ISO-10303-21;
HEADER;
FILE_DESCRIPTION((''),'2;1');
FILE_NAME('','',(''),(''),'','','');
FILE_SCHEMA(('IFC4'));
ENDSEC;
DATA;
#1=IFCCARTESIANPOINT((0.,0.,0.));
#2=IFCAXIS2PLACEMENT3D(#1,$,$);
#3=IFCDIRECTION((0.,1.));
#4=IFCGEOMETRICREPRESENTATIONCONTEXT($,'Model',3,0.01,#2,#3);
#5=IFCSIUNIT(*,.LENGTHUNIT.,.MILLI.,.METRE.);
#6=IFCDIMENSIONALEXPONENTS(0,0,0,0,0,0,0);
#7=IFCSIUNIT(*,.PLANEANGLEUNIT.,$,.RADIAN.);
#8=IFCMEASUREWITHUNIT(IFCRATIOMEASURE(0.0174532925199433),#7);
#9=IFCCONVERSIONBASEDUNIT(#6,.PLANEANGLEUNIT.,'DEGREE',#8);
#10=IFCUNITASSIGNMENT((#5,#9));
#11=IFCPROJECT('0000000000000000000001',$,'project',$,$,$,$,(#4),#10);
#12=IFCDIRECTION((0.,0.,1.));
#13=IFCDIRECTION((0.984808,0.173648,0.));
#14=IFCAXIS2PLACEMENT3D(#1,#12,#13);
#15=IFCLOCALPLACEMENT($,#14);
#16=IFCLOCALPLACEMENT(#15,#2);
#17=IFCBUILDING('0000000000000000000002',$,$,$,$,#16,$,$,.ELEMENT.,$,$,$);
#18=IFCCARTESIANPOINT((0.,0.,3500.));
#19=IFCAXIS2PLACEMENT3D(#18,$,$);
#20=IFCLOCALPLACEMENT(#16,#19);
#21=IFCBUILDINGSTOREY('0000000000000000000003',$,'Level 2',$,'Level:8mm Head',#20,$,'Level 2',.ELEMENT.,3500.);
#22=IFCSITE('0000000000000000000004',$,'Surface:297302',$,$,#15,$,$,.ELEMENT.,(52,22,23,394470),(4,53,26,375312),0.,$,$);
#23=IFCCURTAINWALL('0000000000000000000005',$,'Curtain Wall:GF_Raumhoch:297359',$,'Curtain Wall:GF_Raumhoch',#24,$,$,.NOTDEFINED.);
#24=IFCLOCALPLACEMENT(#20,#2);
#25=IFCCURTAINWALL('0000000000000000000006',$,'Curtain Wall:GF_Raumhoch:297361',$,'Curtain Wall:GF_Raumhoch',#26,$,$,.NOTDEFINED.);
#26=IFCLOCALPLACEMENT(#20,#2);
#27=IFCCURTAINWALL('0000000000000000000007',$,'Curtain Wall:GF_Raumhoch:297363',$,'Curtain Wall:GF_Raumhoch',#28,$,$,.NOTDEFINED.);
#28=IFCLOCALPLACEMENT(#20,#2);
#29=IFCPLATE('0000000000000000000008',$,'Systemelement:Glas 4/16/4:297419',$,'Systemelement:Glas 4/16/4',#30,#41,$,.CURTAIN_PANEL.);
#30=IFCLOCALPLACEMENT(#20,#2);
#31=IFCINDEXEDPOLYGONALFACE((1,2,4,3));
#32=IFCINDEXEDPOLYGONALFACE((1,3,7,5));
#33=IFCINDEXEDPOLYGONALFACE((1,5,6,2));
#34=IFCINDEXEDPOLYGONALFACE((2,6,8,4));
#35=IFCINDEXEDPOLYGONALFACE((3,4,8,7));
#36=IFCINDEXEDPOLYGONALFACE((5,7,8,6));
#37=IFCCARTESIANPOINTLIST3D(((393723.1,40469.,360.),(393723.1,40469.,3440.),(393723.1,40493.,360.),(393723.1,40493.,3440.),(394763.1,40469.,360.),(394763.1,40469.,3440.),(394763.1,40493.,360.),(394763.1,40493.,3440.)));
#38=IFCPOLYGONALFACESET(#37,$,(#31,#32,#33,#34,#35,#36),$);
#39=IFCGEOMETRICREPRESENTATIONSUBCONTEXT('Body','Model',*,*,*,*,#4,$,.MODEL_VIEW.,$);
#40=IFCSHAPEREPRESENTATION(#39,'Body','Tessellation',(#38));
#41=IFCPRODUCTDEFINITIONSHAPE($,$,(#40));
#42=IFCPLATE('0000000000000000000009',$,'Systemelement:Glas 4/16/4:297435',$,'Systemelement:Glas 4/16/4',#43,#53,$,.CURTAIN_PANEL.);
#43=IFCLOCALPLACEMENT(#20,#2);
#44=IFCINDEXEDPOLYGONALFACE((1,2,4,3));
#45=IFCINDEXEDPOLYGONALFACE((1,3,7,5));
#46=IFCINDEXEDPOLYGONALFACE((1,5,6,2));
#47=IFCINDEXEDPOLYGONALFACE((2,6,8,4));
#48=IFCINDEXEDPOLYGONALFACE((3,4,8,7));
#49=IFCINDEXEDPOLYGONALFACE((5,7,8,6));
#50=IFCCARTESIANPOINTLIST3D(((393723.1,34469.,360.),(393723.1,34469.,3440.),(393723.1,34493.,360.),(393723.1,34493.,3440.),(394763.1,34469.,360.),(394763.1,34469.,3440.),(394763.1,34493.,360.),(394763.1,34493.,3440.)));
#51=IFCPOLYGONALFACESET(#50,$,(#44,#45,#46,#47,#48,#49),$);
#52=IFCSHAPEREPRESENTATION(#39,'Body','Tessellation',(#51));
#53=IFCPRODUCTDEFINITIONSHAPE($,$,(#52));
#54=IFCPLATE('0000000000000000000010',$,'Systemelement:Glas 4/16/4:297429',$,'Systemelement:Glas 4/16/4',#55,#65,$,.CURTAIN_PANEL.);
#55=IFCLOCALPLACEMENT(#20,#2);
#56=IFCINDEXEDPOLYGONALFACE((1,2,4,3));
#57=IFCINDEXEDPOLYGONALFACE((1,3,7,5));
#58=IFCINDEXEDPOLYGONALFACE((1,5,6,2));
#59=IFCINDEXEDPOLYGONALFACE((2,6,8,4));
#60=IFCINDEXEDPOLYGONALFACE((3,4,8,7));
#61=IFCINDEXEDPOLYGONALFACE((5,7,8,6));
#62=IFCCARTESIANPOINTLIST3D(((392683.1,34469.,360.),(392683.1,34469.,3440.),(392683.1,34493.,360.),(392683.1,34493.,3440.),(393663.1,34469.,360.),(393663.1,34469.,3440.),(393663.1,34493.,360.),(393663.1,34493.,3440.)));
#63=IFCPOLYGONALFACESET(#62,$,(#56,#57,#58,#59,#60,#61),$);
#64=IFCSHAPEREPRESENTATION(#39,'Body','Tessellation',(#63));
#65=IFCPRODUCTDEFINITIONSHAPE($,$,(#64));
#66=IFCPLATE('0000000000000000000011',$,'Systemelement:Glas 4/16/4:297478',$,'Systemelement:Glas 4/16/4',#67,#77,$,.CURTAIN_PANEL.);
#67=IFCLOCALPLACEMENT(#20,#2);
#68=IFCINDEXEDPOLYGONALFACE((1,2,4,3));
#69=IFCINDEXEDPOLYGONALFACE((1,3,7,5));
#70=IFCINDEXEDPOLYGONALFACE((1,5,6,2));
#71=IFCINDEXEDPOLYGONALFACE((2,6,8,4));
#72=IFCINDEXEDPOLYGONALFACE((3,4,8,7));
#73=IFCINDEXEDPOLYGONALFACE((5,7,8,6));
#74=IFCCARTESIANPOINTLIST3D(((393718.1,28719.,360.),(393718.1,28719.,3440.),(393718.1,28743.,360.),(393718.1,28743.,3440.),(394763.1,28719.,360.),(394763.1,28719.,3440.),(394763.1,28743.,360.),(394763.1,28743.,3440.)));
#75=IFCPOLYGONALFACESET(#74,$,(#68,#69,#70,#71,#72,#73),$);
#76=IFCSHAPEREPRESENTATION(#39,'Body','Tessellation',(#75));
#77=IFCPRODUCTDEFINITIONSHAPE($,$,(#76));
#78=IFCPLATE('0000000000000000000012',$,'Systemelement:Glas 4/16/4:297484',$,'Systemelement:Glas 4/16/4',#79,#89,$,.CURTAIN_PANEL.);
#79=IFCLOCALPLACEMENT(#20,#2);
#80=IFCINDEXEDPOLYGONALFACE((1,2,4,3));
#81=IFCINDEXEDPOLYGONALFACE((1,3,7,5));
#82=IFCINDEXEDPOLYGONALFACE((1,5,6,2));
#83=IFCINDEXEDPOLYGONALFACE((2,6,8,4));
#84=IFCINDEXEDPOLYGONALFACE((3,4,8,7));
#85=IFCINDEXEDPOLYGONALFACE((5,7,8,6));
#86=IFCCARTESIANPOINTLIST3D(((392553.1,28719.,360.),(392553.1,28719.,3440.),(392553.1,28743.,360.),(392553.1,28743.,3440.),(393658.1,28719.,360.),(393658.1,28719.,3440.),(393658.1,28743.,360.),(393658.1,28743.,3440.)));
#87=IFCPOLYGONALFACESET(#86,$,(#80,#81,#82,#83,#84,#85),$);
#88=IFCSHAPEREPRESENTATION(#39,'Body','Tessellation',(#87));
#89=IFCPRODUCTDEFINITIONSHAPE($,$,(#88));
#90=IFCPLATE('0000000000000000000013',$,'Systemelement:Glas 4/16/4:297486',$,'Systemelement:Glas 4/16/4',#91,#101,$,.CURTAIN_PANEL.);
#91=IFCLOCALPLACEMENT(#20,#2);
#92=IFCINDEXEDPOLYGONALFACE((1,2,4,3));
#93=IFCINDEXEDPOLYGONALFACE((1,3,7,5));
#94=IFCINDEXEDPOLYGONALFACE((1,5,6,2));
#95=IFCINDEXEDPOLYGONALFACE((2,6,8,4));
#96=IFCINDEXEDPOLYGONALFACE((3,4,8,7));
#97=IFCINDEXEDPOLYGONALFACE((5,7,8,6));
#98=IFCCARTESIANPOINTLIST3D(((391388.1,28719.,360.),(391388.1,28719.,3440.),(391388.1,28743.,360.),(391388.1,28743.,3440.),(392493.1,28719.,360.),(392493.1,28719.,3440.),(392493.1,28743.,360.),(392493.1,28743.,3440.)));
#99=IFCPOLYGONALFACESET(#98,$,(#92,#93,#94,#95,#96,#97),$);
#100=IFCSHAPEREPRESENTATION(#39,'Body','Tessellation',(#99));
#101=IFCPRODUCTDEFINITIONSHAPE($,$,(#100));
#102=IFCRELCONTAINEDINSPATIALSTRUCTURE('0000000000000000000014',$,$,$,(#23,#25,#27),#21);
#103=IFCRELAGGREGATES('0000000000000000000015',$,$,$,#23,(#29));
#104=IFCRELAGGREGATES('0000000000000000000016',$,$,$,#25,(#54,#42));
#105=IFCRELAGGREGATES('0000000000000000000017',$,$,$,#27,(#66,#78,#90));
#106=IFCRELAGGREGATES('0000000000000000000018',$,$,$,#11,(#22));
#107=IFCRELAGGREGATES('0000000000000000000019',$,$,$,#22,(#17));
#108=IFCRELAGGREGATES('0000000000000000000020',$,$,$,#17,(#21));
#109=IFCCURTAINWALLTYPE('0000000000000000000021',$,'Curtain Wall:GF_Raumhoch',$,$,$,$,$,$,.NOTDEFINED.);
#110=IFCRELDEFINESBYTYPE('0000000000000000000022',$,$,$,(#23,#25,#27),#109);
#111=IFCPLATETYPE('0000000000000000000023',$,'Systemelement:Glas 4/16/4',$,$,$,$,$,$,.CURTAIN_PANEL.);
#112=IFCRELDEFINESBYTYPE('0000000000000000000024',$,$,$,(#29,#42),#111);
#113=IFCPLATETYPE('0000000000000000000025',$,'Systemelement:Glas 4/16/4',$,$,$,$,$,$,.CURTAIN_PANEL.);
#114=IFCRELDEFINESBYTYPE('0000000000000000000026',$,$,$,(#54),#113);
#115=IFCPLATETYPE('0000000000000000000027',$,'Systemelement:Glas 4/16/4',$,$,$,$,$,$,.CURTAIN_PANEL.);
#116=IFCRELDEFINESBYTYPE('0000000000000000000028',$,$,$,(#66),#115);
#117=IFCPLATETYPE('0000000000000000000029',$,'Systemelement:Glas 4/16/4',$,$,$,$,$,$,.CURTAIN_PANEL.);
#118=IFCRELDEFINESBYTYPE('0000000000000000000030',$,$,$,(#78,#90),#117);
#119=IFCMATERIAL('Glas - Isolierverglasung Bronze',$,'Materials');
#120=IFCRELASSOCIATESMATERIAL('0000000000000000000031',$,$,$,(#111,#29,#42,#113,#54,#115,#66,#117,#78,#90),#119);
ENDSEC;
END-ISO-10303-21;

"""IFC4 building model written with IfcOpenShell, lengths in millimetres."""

from ifc_helpers import new_model, entity, si_unit, converted_unit, direction, frame, origin, place, context, subcontext, project, spatial, indexed_curve, outline, extrude, source, transform, mapped, material, type_object, type_shapes, element, aggregate, save


model = new_model("IFC4")

# Units and contexts
model_context = context("Model", 3, precision=0.01, world=origin(), true_north=direction((0.0, 1.0)))
body_context = subcontext(model_context, "Body", "Model", "MODEL_VIEW")
ifc_project = project(units=[si_unit("LENGTHUNIT", "METRE", prefix="MILLI"), converted_unit("PLANEANGLEUNIT", "DEGREE", entity("IfcRatioMeasure", 0.0174532925199433), si_unit("PLANEANGLEUNIT", "RADIAN"), dimensions=[0, 0, 0, 0, 0, 0, 0])], contexts=[model_context])

# Site, building, storey
site_placement = place(None, frame((0.0, 0.0, 0.0), z_axis=(0.0, 0.0, 1.0), x_axis=(0.984808, 0.173648, 0.0)))
site = spatial("IfcSite", under=ifc_project, at=site_placement, Name="Surface:297302", CompositionType="ELEMENT", RefLatitude=(52, 22, 23, 394470), RefLongitude=(4, 53, 26, 375312), RefElevation=0.0)
building_placement = place(site_placement, origin())
building = spatial("IfcBuilding", under=site, at=building_placement, CompositionType="ELEMENT")
storey_placement = place(building_placement, frame((0.0, 0.0, 3500.0)))
storey = spatial("IfcBuildingStorey", under=building, at=storey_placement, Name="Level 2", ObjectType="Level:8mm Head", LongName="Level 2", CompositionType="ELEMENT", Elevation=3500.0)

# Curtain walls
curtain_wall_type = type_object("IfcCurtainWallType", Name="Curtain Wall:GF_Raumhoch", PredefinedType="NOTDEFINED")
curtain_wall_1_placement = place(storey_placement, frame((0.0, 0.0, -3500.0)))
curtain_wall_1 = element("IfcCurtainWall", 1, at=curtain_wall_1_placement, inside=storey, type_object=curtain_wall_type, Name="Curtain Wall:GF_Raumhoch:297359", ObjectType="Curtain Wall:GF_Raumhoch", PredefinedType="NOTDEFINED")
curtain_wall_2_placement = place(storey_placement, frame((0.0, 0.0, -3500.0)))
curtain_wall_2 = element("IfcCurtainWall", 2, at=curtain_wall_2_placement, inside=storey, type_object=curtain_wall_type, Name="Curtain Wall:GF_Raumhoch:297361", ObjectType="Curtain Wall:GF_Raumhoch", PredefinedType="NOTDEFINED")

# Curtain wall
curtain_wall_3_placement = place(storey_placement, frame((0.0, 0.0, -3500.0)))
curtain_wall_3 = element("IfcCurtainWall", 3, at=curtain_wall_3_placement, inside=storey, type_object=curtain_wall_type, Name="Curtain Wall:GF_Raumhoch:297363", ObjectType="Curtain Wall:GF_Raumhoch", PredefinedType="NOTDEFINED")

# Plates
ifc_material_1 = material(Name="Glas - Isolierverglasung Bronze", Category="Materials")
plate_type_1 = type_object("IfcPlateType", Name="Systemelement:Glas 4/16/4", PredefinedType="CURTAIN_PANEL", material=ifc_material_1)
shared_shape_1 = source(origin(), body_context, "Body", "SweptSolid", [
    extrude(outline(indexed_curve([(-12.0, -520.0), (12.0, -520.0), (12.0, 520.0), (-12.0, 520.0), (-12.0, -520.0)], self_intersect=False)), frame((0.0, 0.0, 0.0), z_axis=(0.0, 0.0, 1.0), x_axis=(0.0, 1.0, 0.0)), (0.0, 0.0, 1.0), 3080.0),
])
type_shapes(plate_type_1, [shared_shape_1])
plate_1_placement = place(curtain_wall_1_placement, frame((394243.1, 40481.0, 3860.0), z_axis=(0.0, 0.0, 1.0), x_axis=(-1.0, 0.0, 0.0)))
plate_1 = element("IfcPlate", 4, at=plate_1_placement, type_object=plate_type_1, material=ifc_material_1, Name="Systemelement:Glas 4/16/4:297419", ObjectType="Systemelement:Glas 4/16/4", PredefinedType="CURTAIN_PANEL", context=body_context, shape_type="MappedRepresentation", body=[
    mapped(shared_shape_1, transform((0.0, 0.0, 0.0), scale=1.0)),
])
aggregate(curtain_wall_1, [plate_1])
plate_2_placement = place(curtain_wall_2_placement, frame((394243.1, 34481.0, 3860.0)))
plate_2 = element("IfcPlate", 5, at=plate_2_placement, type_object=plate_type_1, material=ifc_material_1, Name="Systemelement:Glas 4/16/4:297435", ObjectType="Systemelement:Glas 4/16/4", PredefinedType="CURTAIN_PANEL", context=body_context, shape_type="MappedRepresentation", body=[
    mapped(shared_shape_1, transform((0.0, 0.0, 0.0), scale=1.0)),
])
plate_type_2 = type_object("IfcPlateType", Name="Systemelement:Glas 4/16/4", PredefinedType="CURTAIN_PANEL", material=ifc_material_1)
shared_shape_2 = source(origin(), body_context, "Body", "SweptSolid", [
    extrude(outline(indexed_curve([(-12.0, -490.0), (12.0, -490.0), (12.0, 490.0), (-12.0, 490.0), (-12.0, -490.0)], self_intersect=False)), frame((0.0, 0.0, 0.0), z_axis=(0.0, 0.0, 1.0), x_axis=(0.0, 1.0, 0.0)), (0.0, 0.0, 1.0), 3080.0),
])
type_shapes(plate_type_2, [shared_shape_2])
plate_3_placement = place(curtain_wall_2_placement, frame((393173.1, 34481.0, 3860.0)))
plate_3 = element("IfcPlate", 6, at=plate_3_placement, type_object=plate_type_2, material=ifc_material_1, Name="Systemelement:Glas 4/16/4:297429", ObjectType="Systemelement:Glas 4/16/4", PredefinedType="CURTAIN_PANEL", context=body_context, shape_type="MappedRepresentation", body=[
    mapped(shared_shape_2, transform((0.0, 0.0, 0.0), scale=1.0)),
])
aggregate(curtain_wall_2, [plate_3, plate_2])
plate_type_3 = type_object("IfcPlateType", Name="Systemelement:Glas 4/16/4", PredefinedType="CURTAIN_PANEL", material=ifc_material_1)
shared_shape_3 = source(origin(), body_context, "Body", "SweptSolid", [
    extrude(outline(indexed_curve([(-12.0, -522.5), (12.0, -522.5), (12.0, 522.5), (-12.0, 522.5), (-12.0, -522.5)], self_intersect=False)), frame((0.0, 0.0, 0.0), z_axis=(0.0, 0.0, 1.0), x_axis=(0.0, 1.0, 0.0)), (0.0, 0.0, 1.0), 3080.0),
])
type_shapes(plate_type_3, [shared_shape_3])
plate_4_placement = place(curtain_wall_3_placement, frame((394240.6, 28731.0, 3860.0), z_axis=(0.0, 0.0, 1.0), x_axis=(-1.0, 0.0, 0.0)))
plate_4 = element("IfcPlate", 7, at=plate_4_placement, type_object=plate_type_3, material=ifc_material_1, Name="Systemelement:Glas 4/16/4:297478", ObjectType="Systemelement:Glas 4/16/4", PredefinedType="CURTAIN_PANEL", context=body_context, shape_type="MappedRepresentation", body=[
    mapped(shared_shape_3, transform((0.0, 0.0, 0.0), scale=1.0)),
])
plate_type_4 = type_object("IfcPlateType", Name="Systemelement:Glas 4/16/4", PredefinedType="CURTAIN_PANEL", material=ifc_material_1)
shared_shape_4 = source(origin(), body_context, "Body", "SweptSolid", [
    extrude(outline(indexed_curve([(-12.0, -552.5), (12.0, -552.5), (12.0, 552.5), (-12.0, 552.5), (-12.0, -552.5)], self_intersect=False)), frame((0.0, 0.0, 0.0), z_axis=(0.0, 0.0, 1.0), x_axis=(0.0, 1.0, 0.0)), (0.0, 0.0, 1.0), 3080.0),
])
type_shapes(plate_type_4, [shared_shape_4])
plate_5_placement = place(curtain_wall_3_placement, frame((393105.6, 28731.0, 3860.0), z_axis=(0.0, 0.0, 1.0), x_axis=(-1.0, 0.0, 0.0)))
plate_5 = element("IfcPlate", 8, at=plate_5_placement, type_object=plate_type_4, material=ifc_material_1, Name="Systemelement:Glas 4/16/4:297484", ObjectType="Systemelement:Glas 4/16/4", PredefinedType="CURTAIN_PANEL", context=body_context, shape_type="MappedRepresentation", body=[
    mapped(shared_shape_4, transform((0.0, 0.0, 0.0), scale=1.0)),
])
plate_6_placement = place(curtain_wall_3_placement, frame((391940.6, 28731.0, 3860.0), z_axis=(0.0, 0.0, 1.0), x_axis=(-1.0, 0.0, 0.0)))
plate_6 = element("IfcPlate", 9, at=plate_6_placement, type_object=plate_type_4, material=ifc_material_1, Name="Systemelement:Glas 4/16/4:297486", ObjectType="Systemelement:Glas 4/16/4", PredefinedType="CURTAIN_PANEL", context=body_context, shape_type="MappedRepresentation", body=[
    mapped(shared_shape_4, transform((0.0, 0.0, 0.0), scale=1.0)),
])
aggregate(curtain_wall_3, [plate_4, plate_5, plate_6])

save(model, "model.ifc")
